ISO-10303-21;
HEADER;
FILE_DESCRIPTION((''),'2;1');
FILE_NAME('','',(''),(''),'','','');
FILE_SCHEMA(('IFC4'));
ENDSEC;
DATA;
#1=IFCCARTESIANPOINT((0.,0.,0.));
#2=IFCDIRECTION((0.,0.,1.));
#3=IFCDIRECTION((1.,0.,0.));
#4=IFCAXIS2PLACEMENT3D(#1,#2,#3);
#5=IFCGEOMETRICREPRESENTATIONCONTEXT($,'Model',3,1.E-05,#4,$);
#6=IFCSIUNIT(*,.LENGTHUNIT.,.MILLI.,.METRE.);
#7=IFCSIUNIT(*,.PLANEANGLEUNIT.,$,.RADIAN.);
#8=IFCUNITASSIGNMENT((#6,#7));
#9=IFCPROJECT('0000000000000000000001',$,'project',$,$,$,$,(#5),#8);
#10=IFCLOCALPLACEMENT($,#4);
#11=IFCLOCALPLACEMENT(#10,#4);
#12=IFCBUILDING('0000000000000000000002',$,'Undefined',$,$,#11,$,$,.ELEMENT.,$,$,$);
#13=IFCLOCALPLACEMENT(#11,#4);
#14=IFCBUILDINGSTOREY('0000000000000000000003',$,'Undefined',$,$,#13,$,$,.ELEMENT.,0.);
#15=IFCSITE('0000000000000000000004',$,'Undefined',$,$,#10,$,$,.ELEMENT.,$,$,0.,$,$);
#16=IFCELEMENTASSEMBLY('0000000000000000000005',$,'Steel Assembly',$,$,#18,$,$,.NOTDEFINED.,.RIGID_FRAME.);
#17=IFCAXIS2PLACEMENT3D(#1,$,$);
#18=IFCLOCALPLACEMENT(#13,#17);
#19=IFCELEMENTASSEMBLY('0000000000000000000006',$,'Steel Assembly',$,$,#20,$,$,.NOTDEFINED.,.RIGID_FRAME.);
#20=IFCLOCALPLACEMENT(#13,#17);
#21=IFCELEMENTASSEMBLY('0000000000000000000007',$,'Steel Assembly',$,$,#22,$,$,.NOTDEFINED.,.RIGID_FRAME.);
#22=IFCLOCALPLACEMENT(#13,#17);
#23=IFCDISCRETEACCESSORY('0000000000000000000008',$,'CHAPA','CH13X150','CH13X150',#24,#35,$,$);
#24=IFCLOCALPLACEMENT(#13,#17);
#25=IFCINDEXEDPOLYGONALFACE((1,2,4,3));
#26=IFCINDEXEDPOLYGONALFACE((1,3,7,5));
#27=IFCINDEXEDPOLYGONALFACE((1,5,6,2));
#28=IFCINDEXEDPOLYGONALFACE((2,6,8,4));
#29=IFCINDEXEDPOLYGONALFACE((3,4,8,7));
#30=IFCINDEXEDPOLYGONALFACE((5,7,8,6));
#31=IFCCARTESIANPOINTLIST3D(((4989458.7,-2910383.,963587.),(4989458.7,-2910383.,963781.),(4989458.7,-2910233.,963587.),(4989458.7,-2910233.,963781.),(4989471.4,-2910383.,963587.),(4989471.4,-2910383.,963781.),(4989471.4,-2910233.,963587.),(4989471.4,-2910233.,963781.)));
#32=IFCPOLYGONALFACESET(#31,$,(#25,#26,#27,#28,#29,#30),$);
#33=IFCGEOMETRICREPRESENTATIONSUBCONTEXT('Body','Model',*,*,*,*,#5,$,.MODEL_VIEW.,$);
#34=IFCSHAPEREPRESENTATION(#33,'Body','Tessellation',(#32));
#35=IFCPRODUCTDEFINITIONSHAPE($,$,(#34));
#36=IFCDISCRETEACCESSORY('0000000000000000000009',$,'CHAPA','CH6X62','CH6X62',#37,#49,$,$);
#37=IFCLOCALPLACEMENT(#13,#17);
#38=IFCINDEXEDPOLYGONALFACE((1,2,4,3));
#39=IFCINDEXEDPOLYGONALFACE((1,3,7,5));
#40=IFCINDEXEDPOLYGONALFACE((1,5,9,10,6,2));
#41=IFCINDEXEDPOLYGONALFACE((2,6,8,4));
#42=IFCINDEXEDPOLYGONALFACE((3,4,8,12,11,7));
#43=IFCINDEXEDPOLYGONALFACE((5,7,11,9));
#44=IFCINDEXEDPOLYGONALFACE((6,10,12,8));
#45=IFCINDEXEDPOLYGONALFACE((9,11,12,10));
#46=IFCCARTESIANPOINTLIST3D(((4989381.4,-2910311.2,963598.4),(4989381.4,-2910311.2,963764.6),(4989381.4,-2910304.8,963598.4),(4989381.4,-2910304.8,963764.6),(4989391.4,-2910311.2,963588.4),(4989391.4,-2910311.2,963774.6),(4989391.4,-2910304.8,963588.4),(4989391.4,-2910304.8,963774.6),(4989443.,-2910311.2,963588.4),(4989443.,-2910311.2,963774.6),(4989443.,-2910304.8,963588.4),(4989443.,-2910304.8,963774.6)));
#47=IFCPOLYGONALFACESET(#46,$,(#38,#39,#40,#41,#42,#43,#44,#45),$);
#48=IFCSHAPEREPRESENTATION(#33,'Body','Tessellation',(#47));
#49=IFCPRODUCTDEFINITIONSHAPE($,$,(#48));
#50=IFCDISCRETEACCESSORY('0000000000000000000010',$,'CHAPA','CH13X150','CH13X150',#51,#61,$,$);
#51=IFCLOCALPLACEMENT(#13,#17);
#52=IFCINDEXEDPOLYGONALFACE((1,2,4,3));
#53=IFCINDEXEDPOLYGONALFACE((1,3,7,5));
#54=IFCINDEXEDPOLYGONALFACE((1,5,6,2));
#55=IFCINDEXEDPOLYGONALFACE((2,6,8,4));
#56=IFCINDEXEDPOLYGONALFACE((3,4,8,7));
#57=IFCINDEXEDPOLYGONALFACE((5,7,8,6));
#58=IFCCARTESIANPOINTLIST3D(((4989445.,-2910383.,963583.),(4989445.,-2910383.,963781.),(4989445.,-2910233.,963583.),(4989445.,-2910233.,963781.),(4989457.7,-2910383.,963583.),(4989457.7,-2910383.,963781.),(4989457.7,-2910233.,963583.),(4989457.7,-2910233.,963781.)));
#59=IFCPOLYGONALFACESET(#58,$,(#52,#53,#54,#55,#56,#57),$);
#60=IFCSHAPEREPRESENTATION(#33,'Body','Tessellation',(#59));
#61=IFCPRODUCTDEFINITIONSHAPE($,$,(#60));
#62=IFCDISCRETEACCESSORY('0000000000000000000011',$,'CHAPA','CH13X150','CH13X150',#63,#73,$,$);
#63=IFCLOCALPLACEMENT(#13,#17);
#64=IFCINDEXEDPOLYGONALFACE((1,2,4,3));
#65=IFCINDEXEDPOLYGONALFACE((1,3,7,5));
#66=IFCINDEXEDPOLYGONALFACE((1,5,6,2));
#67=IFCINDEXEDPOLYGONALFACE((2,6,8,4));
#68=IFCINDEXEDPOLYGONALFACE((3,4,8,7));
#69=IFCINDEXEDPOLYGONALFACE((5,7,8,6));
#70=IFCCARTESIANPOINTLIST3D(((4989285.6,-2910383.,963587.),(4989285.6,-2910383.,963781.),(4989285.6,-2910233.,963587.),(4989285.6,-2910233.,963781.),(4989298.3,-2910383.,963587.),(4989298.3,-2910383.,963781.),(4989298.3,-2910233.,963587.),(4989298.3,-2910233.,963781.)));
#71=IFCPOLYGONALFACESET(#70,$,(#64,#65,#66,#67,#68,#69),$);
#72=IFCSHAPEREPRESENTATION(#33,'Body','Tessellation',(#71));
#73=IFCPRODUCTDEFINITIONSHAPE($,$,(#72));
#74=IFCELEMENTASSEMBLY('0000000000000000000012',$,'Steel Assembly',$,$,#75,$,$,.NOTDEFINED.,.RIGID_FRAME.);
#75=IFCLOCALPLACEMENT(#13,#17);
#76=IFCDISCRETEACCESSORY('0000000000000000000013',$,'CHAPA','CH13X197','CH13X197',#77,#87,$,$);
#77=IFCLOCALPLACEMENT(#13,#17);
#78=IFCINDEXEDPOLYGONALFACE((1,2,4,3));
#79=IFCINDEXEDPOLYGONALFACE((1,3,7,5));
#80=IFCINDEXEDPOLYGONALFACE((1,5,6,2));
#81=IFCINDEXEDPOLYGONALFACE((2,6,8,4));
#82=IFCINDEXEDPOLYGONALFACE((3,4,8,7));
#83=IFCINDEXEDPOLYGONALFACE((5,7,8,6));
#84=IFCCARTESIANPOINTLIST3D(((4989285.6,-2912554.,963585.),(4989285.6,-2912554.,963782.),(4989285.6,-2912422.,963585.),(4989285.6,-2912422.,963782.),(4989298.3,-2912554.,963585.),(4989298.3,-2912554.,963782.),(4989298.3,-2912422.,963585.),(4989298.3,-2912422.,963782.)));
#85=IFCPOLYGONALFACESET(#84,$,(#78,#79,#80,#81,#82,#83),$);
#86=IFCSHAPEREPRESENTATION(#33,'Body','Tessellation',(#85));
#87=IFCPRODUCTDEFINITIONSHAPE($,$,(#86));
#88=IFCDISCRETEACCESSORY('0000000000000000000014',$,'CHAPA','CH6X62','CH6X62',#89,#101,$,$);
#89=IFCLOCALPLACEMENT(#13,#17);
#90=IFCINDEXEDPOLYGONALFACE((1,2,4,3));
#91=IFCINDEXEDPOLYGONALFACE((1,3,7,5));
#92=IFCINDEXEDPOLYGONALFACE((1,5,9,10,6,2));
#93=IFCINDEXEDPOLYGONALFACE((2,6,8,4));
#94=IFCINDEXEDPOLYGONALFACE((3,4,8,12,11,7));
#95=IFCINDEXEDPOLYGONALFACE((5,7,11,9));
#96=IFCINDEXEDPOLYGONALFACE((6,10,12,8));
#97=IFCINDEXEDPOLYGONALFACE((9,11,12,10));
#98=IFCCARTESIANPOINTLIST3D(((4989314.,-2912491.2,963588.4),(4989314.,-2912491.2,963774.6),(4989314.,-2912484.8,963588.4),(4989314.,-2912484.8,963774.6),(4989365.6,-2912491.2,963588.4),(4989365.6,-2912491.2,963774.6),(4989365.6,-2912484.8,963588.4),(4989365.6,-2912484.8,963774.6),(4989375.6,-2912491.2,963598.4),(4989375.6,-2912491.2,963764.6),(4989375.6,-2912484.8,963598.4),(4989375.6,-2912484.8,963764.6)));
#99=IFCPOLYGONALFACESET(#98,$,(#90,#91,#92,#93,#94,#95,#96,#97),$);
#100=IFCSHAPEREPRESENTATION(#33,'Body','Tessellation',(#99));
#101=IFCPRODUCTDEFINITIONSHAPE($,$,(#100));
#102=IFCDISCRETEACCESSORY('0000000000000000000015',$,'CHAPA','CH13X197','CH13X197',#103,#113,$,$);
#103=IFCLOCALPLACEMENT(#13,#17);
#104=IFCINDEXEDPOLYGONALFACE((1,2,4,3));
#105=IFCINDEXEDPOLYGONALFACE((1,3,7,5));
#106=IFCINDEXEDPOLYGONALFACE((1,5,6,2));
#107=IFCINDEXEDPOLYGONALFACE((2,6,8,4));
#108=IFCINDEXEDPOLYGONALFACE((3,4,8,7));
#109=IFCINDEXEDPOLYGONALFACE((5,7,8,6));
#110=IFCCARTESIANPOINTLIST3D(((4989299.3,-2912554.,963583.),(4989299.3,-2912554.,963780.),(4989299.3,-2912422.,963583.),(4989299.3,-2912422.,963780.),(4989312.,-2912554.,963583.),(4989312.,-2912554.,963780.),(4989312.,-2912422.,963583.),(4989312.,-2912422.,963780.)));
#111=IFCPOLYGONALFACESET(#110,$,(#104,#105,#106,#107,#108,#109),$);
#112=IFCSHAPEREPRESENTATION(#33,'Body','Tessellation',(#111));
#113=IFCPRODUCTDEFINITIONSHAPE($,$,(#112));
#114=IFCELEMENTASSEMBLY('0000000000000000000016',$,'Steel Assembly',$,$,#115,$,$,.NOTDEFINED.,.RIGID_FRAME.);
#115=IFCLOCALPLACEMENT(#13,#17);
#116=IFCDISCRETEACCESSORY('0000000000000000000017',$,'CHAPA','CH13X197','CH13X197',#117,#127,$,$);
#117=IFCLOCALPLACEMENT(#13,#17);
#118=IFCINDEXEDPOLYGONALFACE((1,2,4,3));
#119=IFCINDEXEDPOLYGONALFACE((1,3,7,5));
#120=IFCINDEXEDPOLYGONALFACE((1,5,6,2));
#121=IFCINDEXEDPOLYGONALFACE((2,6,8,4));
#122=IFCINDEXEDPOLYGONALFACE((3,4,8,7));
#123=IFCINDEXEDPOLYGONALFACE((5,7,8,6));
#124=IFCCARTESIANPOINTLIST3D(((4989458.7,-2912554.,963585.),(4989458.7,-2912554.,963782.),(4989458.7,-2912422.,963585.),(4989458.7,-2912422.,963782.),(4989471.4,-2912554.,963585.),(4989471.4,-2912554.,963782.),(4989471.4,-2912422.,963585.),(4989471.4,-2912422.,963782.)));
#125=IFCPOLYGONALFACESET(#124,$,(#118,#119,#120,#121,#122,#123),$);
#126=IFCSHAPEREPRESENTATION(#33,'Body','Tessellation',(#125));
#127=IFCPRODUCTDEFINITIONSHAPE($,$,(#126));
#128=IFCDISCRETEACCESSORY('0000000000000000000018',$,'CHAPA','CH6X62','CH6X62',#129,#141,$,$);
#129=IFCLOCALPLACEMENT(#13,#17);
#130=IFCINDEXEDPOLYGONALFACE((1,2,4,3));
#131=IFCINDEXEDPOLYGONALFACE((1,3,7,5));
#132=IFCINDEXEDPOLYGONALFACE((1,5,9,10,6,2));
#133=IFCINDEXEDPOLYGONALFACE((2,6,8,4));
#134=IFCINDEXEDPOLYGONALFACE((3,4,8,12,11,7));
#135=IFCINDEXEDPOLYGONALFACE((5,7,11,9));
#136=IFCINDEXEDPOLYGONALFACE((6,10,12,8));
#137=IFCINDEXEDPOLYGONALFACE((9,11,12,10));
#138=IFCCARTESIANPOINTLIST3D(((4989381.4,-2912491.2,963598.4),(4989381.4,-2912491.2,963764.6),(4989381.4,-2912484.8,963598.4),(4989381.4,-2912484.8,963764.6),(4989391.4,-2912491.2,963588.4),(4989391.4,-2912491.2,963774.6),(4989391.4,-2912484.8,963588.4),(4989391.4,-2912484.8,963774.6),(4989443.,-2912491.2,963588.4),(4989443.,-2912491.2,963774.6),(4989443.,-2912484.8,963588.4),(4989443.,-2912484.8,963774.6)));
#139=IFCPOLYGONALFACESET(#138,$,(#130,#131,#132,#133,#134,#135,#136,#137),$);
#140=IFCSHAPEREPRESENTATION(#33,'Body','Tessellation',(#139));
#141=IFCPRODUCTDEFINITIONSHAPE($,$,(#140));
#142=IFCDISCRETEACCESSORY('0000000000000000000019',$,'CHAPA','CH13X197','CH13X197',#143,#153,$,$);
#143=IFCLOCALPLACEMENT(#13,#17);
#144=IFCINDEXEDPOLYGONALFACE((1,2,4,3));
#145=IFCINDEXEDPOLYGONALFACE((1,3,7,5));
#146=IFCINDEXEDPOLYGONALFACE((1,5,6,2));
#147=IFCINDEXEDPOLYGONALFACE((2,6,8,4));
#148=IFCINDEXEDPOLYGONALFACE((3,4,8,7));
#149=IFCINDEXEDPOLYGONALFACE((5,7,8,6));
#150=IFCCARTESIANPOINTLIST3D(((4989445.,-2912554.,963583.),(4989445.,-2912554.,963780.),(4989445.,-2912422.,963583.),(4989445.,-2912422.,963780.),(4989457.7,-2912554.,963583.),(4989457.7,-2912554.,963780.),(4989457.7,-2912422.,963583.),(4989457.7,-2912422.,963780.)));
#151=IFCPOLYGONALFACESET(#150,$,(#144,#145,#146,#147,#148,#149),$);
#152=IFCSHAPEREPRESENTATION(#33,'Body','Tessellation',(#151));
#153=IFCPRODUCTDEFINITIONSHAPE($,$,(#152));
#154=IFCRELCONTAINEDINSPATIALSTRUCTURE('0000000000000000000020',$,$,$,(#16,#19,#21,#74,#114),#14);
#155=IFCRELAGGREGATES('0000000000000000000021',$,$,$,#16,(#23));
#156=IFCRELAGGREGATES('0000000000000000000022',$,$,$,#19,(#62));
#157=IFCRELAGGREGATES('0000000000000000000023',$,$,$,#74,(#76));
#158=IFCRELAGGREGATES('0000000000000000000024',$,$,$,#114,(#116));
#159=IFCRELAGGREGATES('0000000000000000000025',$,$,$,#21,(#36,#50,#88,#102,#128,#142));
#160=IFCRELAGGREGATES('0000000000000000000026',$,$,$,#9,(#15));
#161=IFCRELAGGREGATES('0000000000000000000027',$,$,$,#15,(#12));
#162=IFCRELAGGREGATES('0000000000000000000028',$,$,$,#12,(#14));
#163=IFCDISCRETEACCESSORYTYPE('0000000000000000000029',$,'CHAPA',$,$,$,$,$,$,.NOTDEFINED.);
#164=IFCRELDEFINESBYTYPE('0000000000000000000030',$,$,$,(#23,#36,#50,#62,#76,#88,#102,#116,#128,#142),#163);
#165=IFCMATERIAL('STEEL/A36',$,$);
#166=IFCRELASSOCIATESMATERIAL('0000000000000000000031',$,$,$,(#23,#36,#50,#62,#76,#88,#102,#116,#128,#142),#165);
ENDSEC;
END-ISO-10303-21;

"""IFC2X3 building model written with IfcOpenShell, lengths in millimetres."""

from ifc_helpers import new_model, si_unit, frame, origin_with_axes, place, context, subcontext, project, spatial, polyline, outline, extrude, material, type_object, element, aggregate, save


model = new_model("IFC2X3")

# Units and contexts
model_context = context("Model", 3, precision=1e-05, world=origin_with_axes())
body_context = subcontext(model_context, "Body", "Model", "MODEL_VIEW")
ifc_project = project(units=[si_unit("LENGTHUNIT", "METRE", prefix="MILLI"), si_unit("PLANEANGLEUNIT", "RADIAN")], contexts=[model_context])

# Site, building, storey
site_placement = place(None, origin_with_axes())
site = spatial("IfcSite", under=ifc_project, at=site_placement, Name="Undefined", CompositionType="ELEMENT", RefElevation=0.0)
building_placement = place(site_placement, origin_with_axes())
building = spatial("IfcBuilding", under=site, at=building_placement, Name="Undefined", CompositionType="ELEMENT")
storey_placement = place(building_placement, origin_with_axes())
storey = spatial("IfcBuildingStorey", under=building, at=storey_placement, Name="Undefined", CompositionType="ELEMENT", Elevation=0.0)

# Element assemblies
assembly_1_placement = place(storey_placement, origin_with_axes())
assembly_1 = element("IfcElementAssembly", 1, at=assembly_1_placement, inside=storey, Name="Steel Assembly", AssemblyPlace="NOTDEFINED", PredefinedType="RIGID_FRAME")
assembly_2_placement = place(storey_placement, origin_with_axes())
assembly_2 = element("IfcElementAssembly", 2, at=assembly_2_placement, inside=storey, Name="Steel Assembly", AssemblyPlace="NOTDEFINED", PredefinedType="RIGID_FRAME")

# Shared definitions
ifc_material_1 = material(Name="STEEL/A36")
discrete_accessory_type = type_object("IfcDiscreteAccessoryType", Name="CHAPA")

# Element assembly
assembly_3_placement = place(storey_placement, origin_with_axes())
assembly_3 = element("IfcElementAssembly", 3, at=assembly_3_placement, inside=storey, Name="Steel Assembly", AssemblyPlace="NOTDEFINED", PredefinedType="RIGID_FRAME")

# Discrete accessories
discrete_accessory_1_placement = place(assembly_1_placement, frame((4989465.0, -2910308.0, 963781.0), z_axis=(1.0, 0.0, 0.0), x_axis=(0.0, 0.0, -1.0)))
discrete_accessory_1 = element("IfcDiscreteAccessory", 4, at=discrete_accessory_1_placement, type_object=discrete_accessory_type, material=ifc_material_1, Name="CHAPA", Description="CH13X150", ObjectType="CH13X150", context=body_context, shape_type="SweptSolid", body=[
    extrude(outline(polyline([(194.0, -75.0), (0.0, -75.0), (0.0, 75.0), (194.0, 75.0), (194.0, -75.0)])), frame((0.0, 0.0, -6.3), z_axis=(0.0, 0.0, 1.0), x_axis=(1.0, 0.0, 0.0)), (0.0, 0.0, 1.0), 12.7),
])
aggregate(assembly_1, [discrete_accessory_1])
discrete_accessory_2_placement = place(assembly_3_placement, frame((4989381.4, -2910308.0, 963774.6), z_axis=(0.0, 1.0, 0.0), x_axis=(1.0, 0.0, 0.0)))
discrete_accessory_2 = element("IfcDiscreteAccessory", 5, at=discrete_accessory_2_placement, type_object=discrete_accessory_type, material=ifc_material_1, Name="CHAPA", Description="CH6X62", ObjectType="CH6X62", context=body_context, shape_type="SweptSolid", body=[
    extrude(outline(polyline([(0.0, 10.0), (10.0, 0.0), (61.6, 0.0), (61.6, 186.2), (10.0, 186.2), (0.0, 176.2), (0.0, 10.0)])), frame((0.0, 0.0, -3.2), z_axis=(0.0, 0.0, 1.0), x_axis=(1.0, 0.0, 0.0)), (0.0, 0.0, 1.0), 6.4),
])
discrete_accessory_3_placement = place(assembly_3_placement, frame((4989451.3, -2910308.0, 963781.0), z_axis=(1.0, 0.0, 0.0), x_axis=(0.0, 0.0, -1.0)))
discrete_accessory_3 = element("IfcDiscreteAccessory", 6, at=discrete_accessory_3_placement, type_object=discrete_accessory_type, material=ifc_material_1, Name="CHAPA", Description="CH13X150", ObjectType="CH13X150", context=body_context, shape_type="SweptSolid", body=[
    extrude(outline(polyline([(198.0, -75.0), (0.0, -75.0), (0.0, 75.0), (198.0, 75.0), (198.0, -75.0)])), frame((0.0, 0.0, -6.3), z_axis=(0.0, 0.0, 1.0), x_axis=(1.0, 0.0, 0.0)), (0.0, 0.0, 1.0), 12.7),
])
discrete_accessory_4_placement = place(assembly_2_placement, frame((4989291.9, -2910308.0, 963781.0), z_axis=(-1.0, 0.0, 0.0), x_axis=(0.0, 0.0, -1.0)))
discrete_accessory_4 = element("IfcDiscreteAccessory", 7, at=discrete_accessory_4_placement, type_object=discrete_accessory_type, material=ifc_material_1, Name="CHAPA", Description="CH13X150", ObjectType="CH13X150", context=body_context, shape_type="SweptSolid", body=[
    extrude(outline(polyline([(194.0, 75.0), (194.0, -75.0), (0.0, -75.0), (0.0, 75.0), (194.0, 75.0)])), frame((0.0, 0.0, -6.3), z_axis=(0.0, 0.0, 1.0), x_axis=(1.0, 0.0, 0.0)), (0.0, 0.0, 1.0), 12.7),
])
aggregate(assembly_2, [discrete_accessory_4])

# Element assembly, discrete accessory
assembly_4_placement = place(storey_placement, origin_with_axes())
assembly_4 = element("IfcElementAssembly", 8, at=assembly_4_placement, inside=storey, Name="Steel Assembly", AssemblyPlace="NOTDEFINED", PredefinedType="RIGID_FRAME")
discrete_accessory_5_placement = place(assembly_4_placement, frame((4989291.9, -2912488.0, 963782.0), z_axis=(-1.0, 0.0, 0.0), x_axis=(0.0, 0.0, -1.0)))
discrete_accessory_5 = element("IfcDiscreteAccessory", 9, at=discrete_accessory_5_placement, type_object=discrete_accessory_type, material=ifc_material_1, Name="CHAPA", Description="CH13X197", ObjectType="CH13X197", context=body_context, shape_type="SweptSolid", body=[
    extrude(outline(polyline([(197.0, 66.0), (197.0, -66.0), (0.0, -66.0), (0.0, 66.0), (197.0, 66.0)])), frame((0.0, 0.0, -6.3), z_axis=(0.0, 0.0, 1.0), x_axis=(1.0, 0.0, 0.0)), (0.0, 0.0, 1.0), 12.7),
])
aggregate(assembly_4, [discrete_accessory_5])

# Discrete accessories
discrete_accessory_6_placement = place(assembly_3_placement, frame((4989375.6, -2912488.0, 963774.6), z_axis=(0.0, -1.0, 0.0), x_axis=(-1.0, 0.0, 0.0)))
discrete_accessory_6 = element("IfcDiscreteAccessory", 10, at=discrete_accessory_6_placement, type_object=discrete_accessory_type, material=ifc_material_1, Name="CHAPA", Description="CH6X62", ObjectType="CH6X62", context=body_context, shape_type="SweptSolid", body=[
    extrude(outline(polyline([(0.0, 10.0), (10.0, 0.0), (61.6, 0.0), (61.6, 186.2), (10.0, 186.2), (0.0, 176.2), (0.0, 10.0)])), frame((0.0, 0.0, -3.2), z_axis=(0.0, 0.0, 1.0), x_axis=(1.0, 0.0, 0.0)), (0.0, 0.0, 1.0), 6.4),
])
discrete_accessory_7_placement = place(assembly_3_placement, frame((4989305.6, -2912488.0, 963780.0), z_axis=(-1.0, 0.0, 0.0), x_axis=(0.0, 0.0, -1.0)))
discrete_accessory_7 = element("IfcDiscreteAccessory", 11, at=discrete_accessory_7_placement, type_object=discrete_accessory_type, material=ifc_material_1, Name="CHAPA", Description="CH13X197", ObjectType="CH13X197", context=body_context, shape_type="SweptSolid", body=[
    extrude(outline(polyline([(197.0, 66.0), (197.0, -66.0), (0.0, -66.0), (0.0, 66.0), (197.0, 66.0)])), frame((0.0, 0.0, -6.3), z_axis=(0.0, 0.0, 1.0), x_axis=(1.0, 0.0, 0.0)), (0.0, 0.0, 1.0), 12.7),
])

# Element assembly, discrete accessory
assembly_5_placement = place(storey_placement, origin_with_axes())
assembly_5 = element("IfcElementAssembly", 12, at=assembly_5_placement, inside=storey, Name="Steel Assembly", AssemblyPlace="NOTDEFINED", PredefinedType="RIGID_FRAME")
discrete_accessory_8_placement = place(assembly_5_placement, frame((4989465.0, -2912488.0, 963782.0), z_axis=(1.0, 0.0, 0.0), x_axis=(0.0, 0.0, -1.0)))
discrete_accessory_8 = element("IfcDiscreteAccessory", 13, at=discrete_accessory_8_placement, type_object=discrete_accessory_type, material=ifc_material_1, Name="CHAPA", Description="CH13X197", ObjectType="CH13X197", context=body_context, shape_type="SweptSolid", body=[
    extrude(outline(polyline([(197.0, -66.0), (0.0, -66.0), (0.0, 66.0), (197.0, 66.0), (197.0, -66.0)])), frame((0.0, 0.0, -6.3), z_axis=(0.0, 0.0, 1.0), x_axis=(1.0, 0.0, 0.0)), (0.0, 0.0, 1.0), 12.7),
])
aggregate(assembly_5, [discrete_accessory_8])

# Discrete accessories
discrete_accessory_9_placement = place(assembly_3_placement, frame((4989381.4, -2912488.0, 963774.6), z_axis=(0.0, 1.0, 0.0), x_axis=(1.0, 0.0, 0.0)))
discrete_accessory_9 = element("IfcDiscreteAccessory", 14, at=discrete_accessory_9_placement, type_object=discrete_accessory_type, material=ifc_material_1, Name="CHAPA", Description="CH6X62", ObjectType="CH6X62", context=body_context, shape_type="SweptSolid", body=[
    extrude(outline(polyline([(0.0, 10.0), (10.0, 0.0), (61.6, 0.0), (61.6, 186.2), (10.0, 186.2), (0.0, 176.2), (0.0, 10.0)])), frame((0.0, 0.0, -3.2), z_axis=(0.0, 0.0, 1.0), x_axis=(1.0, 0.0, 0.0)), (0.0, 0.0, 1.0), 6.4),
])
discrete_accessory_10_placement = place(assembly_3_placement, frame((4989451.3, -2912488.0, 963780.0), z_axis=(1.0, 0.0, 0.0), x_axis=(0.0, 0.0, -1.0)))
discrete_accessory_10 = element("IfcDiscreteAccessory", 15, at=discrete_accessory_10_placement, type_object=discrete_accessory_type, material=ifc_material_1, Name="CHAPA", Description="CH13X197", ObjectType="CH13X197", context=body_context, shape_type="SweptSolid", body=[
    extrude(outline(polyline([(197.0, -66.0), (0.0, -66.0), (0.0, 66.0), (197.0, 66.0), (197.0, -66.0)])), frame((0.0, 0.0, -6.3), z_axis=(0.0, 0.0, 1.0), x_axis=(1.0, 0.0, 0.0)), (0.0, 0.0, 1.0), 12.7),
])
aggregate(assembly_3, [discrete_accessory_2, discrete_accessory_3, discrete_accessory_6, discrete_accessory_7, discrete_accessory_9, discrete_accessory_10])

save(model, "model.ifc")
